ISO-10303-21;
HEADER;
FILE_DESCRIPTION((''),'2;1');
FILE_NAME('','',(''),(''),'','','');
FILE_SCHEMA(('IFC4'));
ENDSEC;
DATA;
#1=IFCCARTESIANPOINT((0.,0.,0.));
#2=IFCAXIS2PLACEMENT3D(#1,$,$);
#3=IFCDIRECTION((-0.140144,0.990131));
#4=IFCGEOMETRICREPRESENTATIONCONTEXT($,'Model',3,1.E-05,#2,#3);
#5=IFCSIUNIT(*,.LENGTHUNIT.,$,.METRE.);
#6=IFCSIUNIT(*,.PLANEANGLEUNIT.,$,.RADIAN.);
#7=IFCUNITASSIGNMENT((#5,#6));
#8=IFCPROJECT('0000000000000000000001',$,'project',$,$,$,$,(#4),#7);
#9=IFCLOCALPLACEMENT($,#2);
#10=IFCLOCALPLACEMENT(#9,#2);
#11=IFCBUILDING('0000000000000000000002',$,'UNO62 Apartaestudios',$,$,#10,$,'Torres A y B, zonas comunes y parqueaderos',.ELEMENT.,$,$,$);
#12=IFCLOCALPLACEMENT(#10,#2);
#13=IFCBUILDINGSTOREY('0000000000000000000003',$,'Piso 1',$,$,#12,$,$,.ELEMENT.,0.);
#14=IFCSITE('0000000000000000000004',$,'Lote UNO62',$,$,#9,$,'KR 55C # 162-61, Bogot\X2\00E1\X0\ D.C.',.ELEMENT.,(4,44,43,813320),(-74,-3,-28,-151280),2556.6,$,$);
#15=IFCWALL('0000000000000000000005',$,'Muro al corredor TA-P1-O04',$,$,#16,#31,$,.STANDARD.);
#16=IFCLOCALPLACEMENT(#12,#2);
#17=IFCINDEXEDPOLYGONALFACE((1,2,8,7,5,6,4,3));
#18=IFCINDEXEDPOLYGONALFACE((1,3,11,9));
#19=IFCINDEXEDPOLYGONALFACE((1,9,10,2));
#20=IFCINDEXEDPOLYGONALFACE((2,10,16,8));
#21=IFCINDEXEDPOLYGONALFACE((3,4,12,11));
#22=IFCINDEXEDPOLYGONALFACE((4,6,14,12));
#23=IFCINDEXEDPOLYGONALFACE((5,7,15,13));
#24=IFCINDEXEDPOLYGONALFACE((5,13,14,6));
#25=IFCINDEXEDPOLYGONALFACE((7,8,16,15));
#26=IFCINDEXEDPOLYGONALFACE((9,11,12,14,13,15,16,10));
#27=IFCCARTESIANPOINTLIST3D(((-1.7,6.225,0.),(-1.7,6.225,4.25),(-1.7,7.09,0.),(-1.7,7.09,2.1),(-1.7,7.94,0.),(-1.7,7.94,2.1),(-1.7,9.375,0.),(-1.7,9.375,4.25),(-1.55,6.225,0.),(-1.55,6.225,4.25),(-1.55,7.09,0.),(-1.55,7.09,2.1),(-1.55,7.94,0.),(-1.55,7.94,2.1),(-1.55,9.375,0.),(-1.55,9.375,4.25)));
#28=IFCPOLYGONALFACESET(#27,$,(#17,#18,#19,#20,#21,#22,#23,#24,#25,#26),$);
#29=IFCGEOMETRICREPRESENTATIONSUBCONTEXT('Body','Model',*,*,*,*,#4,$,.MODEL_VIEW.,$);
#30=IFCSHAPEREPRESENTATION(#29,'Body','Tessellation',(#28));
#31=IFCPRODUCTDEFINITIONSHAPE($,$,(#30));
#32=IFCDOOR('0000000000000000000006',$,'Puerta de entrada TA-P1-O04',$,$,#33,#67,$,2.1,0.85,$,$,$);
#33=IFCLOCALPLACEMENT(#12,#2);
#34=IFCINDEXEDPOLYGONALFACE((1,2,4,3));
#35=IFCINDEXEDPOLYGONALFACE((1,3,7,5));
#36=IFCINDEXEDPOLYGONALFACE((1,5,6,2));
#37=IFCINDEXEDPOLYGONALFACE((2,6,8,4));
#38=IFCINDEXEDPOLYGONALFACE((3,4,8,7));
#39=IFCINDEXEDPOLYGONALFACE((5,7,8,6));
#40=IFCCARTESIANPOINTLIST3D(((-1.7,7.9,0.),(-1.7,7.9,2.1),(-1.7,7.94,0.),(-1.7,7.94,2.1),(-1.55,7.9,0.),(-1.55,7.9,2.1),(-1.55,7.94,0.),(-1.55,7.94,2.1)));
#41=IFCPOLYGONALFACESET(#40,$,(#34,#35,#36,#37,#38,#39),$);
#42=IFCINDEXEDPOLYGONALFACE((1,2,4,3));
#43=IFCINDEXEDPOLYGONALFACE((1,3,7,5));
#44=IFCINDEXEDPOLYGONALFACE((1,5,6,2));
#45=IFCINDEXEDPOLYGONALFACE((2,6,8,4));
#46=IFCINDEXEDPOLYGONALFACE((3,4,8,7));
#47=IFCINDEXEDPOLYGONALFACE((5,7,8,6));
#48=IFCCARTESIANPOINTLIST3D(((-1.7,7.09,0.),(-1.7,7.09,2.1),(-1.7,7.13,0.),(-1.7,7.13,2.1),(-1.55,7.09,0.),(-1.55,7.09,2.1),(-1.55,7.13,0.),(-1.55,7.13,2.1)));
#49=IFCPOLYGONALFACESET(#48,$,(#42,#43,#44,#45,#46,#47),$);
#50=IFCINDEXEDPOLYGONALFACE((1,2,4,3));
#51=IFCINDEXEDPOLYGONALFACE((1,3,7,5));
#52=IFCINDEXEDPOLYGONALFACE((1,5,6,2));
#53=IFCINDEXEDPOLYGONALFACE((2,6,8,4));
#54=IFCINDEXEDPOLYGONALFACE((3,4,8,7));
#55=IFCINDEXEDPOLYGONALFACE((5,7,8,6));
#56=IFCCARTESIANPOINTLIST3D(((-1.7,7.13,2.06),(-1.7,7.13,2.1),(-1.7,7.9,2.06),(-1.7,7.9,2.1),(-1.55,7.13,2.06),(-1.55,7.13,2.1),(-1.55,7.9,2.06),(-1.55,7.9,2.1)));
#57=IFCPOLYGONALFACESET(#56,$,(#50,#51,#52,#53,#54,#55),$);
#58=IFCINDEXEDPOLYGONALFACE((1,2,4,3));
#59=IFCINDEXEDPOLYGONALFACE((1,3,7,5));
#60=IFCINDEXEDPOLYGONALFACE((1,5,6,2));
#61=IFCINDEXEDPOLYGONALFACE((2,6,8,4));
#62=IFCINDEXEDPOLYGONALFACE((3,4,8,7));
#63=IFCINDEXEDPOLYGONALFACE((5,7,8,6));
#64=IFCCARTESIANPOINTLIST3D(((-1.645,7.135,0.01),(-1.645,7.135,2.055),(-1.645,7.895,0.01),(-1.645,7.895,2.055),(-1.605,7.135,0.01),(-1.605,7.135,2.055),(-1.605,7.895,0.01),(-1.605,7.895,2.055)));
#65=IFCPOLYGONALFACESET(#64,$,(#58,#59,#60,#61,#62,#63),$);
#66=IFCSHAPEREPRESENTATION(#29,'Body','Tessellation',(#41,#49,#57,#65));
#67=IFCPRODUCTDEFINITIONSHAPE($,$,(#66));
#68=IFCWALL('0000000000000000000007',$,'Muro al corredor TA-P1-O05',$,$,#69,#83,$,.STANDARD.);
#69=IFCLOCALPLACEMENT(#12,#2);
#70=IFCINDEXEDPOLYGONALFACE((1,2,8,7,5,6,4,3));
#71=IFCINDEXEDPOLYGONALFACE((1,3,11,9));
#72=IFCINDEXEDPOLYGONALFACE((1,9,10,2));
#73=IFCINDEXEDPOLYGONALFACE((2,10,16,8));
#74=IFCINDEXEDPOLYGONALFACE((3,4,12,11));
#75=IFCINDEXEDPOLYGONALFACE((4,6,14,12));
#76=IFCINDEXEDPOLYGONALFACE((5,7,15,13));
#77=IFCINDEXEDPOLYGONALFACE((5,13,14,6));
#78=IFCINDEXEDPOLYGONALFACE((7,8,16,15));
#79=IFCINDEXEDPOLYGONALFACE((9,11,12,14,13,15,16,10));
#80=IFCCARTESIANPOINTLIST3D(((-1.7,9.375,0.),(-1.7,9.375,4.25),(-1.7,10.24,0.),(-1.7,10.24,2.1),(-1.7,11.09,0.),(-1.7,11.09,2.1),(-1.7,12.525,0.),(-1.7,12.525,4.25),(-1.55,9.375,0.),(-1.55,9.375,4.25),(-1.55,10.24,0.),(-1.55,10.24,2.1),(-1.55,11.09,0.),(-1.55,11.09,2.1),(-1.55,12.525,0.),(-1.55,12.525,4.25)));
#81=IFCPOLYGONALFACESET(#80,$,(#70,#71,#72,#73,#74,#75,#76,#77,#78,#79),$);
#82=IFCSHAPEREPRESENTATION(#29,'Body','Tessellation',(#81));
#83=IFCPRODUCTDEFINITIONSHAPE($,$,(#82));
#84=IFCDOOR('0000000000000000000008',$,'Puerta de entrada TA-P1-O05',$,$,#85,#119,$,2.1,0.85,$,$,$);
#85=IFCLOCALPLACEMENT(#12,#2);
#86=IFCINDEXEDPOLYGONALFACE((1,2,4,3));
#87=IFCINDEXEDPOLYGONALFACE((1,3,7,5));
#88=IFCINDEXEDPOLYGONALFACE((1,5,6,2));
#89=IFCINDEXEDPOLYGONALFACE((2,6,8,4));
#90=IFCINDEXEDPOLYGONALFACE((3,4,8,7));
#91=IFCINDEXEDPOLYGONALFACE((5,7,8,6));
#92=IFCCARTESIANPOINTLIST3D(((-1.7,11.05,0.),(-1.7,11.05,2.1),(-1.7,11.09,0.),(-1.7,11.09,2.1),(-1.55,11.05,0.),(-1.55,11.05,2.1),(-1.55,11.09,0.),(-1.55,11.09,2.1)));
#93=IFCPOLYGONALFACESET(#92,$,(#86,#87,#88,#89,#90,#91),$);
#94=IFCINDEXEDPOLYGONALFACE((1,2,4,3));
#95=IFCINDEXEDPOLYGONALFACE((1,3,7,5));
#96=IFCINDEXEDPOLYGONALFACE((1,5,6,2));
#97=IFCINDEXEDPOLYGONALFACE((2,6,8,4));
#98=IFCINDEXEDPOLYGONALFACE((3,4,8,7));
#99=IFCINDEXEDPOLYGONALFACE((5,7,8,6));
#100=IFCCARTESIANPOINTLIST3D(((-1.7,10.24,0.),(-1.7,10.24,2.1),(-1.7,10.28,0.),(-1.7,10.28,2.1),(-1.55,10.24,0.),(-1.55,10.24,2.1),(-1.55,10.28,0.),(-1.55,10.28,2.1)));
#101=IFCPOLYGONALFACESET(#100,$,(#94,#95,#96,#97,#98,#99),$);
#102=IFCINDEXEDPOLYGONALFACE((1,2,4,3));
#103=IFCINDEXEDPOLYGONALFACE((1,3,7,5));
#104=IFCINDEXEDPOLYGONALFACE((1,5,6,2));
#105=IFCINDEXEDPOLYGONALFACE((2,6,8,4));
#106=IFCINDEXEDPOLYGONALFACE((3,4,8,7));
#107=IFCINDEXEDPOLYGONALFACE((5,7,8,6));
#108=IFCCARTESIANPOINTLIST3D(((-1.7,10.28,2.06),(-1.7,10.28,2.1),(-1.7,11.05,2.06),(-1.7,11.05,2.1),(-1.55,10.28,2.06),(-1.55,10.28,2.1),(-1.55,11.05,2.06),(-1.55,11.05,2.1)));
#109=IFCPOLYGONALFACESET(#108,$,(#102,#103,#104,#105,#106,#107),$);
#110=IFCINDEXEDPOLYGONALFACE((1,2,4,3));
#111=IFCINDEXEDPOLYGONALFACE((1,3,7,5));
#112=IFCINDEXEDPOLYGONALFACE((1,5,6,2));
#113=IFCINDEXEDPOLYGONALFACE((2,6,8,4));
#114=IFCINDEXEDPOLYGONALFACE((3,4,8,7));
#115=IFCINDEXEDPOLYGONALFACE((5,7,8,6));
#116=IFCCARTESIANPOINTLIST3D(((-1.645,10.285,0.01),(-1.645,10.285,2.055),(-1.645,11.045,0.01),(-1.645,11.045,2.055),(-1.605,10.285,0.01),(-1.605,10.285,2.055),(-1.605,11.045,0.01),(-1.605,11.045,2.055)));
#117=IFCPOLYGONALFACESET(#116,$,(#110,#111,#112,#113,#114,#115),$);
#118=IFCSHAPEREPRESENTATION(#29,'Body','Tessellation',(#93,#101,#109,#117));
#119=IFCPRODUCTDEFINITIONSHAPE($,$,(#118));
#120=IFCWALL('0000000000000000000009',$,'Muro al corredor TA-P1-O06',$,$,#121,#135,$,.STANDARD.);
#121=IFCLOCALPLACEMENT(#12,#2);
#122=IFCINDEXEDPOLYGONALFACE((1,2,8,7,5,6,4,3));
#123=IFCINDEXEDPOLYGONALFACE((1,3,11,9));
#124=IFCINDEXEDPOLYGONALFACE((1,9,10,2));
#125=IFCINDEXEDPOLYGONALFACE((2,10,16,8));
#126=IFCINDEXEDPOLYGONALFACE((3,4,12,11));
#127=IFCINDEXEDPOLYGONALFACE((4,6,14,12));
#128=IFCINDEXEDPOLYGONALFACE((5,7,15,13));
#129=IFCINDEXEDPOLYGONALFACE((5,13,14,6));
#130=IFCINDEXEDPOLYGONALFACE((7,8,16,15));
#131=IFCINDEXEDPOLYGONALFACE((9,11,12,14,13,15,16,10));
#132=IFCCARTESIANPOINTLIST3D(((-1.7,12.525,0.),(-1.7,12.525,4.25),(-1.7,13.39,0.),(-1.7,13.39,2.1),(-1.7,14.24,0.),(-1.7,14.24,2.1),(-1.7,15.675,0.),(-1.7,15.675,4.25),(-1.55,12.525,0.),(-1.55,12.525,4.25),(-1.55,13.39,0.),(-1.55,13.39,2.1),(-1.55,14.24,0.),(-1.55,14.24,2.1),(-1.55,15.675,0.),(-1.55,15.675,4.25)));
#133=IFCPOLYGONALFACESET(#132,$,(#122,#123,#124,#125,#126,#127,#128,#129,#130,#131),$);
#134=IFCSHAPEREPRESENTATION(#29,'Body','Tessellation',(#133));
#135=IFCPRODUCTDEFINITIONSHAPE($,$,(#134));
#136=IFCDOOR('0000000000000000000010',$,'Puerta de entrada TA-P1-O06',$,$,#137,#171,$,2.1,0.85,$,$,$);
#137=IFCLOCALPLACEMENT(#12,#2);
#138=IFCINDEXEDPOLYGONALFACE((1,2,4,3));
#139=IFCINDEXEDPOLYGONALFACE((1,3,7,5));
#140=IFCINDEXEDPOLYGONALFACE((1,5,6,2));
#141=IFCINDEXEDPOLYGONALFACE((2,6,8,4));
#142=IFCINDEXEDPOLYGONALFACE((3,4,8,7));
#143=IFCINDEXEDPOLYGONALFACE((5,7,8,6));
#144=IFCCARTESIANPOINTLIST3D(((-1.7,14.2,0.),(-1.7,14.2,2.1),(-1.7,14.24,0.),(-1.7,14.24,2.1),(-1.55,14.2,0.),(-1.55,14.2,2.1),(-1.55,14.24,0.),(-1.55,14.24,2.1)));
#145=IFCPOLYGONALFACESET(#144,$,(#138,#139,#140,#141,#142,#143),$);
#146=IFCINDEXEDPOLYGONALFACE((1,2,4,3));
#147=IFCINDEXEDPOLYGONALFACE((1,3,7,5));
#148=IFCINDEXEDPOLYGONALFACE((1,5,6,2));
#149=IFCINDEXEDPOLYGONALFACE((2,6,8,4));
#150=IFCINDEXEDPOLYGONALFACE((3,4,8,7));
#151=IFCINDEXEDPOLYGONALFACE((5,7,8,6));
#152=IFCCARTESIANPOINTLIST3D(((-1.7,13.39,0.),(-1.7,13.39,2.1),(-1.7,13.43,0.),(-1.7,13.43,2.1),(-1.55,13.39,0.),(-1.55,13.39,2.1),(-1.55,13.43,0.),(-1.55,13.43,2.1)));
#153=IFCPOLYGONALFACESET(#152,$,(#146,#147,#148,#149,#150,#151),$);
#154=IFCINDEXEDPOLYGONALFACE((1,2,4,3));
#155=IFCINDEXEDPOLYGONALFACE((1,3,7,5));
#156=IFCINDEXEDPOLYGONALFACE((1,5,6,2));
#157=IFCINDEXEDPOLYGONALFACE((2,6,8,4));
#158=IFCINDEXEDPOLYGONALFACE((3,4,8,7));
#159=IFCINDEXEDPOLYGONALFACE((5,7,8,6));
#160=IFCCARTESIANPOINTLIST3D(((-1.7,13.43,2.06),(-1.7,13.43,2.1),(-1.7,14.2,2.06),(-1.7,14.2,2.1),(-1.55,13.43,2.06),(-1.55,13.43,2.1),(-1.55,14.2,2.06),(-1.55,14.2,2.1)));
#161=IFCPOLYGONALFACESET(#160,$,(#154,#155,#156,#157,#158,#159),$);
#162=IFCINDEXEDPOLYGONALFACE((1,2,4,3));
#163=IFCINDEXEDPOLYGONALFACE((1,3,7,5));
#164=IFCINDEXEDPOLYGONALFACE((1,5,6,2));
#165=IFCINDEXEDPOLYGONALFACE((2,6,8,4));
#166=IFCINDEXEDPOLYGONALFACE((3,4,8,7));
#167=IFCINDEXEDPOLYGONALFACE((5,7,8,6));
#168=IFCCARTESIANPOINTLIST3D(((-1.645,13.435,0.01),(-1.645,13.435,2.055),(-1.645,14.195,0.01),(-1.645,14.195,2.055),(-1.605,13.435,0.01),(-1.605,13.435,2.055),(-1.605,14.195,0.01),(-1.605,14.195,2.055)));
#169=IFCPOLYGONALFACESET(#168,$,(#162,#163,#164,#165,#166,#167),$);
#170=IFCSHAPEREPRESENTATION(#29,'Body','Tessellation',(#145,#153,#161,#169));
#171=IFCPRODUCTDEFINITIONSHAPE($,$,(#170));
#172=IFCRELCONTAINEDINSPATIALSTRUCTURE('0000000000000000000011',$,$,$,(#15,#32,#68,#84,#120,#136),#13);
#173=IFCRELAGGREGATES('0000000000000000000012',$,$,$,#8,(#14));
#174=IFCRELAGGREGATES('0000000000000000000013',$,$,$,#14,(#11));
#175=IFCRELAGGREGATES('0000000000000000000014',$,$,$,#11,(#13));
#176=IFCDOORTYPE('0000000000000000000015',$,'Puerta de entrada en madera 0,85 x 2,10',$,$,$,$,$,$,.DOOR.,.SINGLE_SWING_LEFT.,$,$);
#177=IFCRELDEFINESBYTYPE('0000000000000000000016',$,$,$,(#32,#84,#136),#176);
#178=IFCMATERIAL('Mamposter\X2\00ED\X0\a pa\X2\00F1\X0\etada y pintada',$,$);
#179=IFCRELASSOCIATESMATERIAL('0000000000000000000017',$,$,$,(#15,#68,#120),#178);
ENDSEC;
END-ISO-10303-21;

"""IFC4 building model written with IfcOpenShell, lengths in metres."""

from ifc_helpers import new_model, si_unit, direction, frame, frame_2d, origin, place, context, subcontext, project, spatial, rectangle, extrude, source, transform, mapped, material, type_object, type_shapes, element, fill, save


model = new_model("IFC4")

# Units and contexts
model_context = context("Model", 3, precision=1e-05, world=origin(), true_north=direction((-0.140144, 0.990131)))
body_context = subcontext(model_context, "Body", "Model", "MODEL_VIEW")
ifc_project = project(units=[si_unit("LENGTHUNIT", "METRE"), si_unit("PLANEANGLEUNIT", "RADIAN")], contexts=[model_context])

# Site, building, storey
site_placement = place(None, origin())
site = spatial("IfcSite", under=ifc_project, at=site_placement, Name="Lote UNO62", LongName="KR 55C # 162-61, Bogotá D.C.", CompositionType="ELEMENT", RefLatitude=(4, 44, 43, 813320), RefLongitude=(-74, -3, -28, -151280), RefElevation=2556.6)
building_placement = place(site_placement, origin())
building = spatial("IfcBuilding", under=site, at=building_placement, Name="UNO62 Apartaestudios", LongName="Torres A y B, zonas comunes y parqueaderos", CompositionType="ELEMENT")
storey_placement = place(building_placement, origin())
storey = spatial("IfcBuildingStorey", under=building, at=storey_placement, Name="Piso 1", CompositionType="ELEMENT", Elevation=0.0)

# Walls, openings, doors
ifc_material = material(Name="Mampostería pañetada y pintada")
wall_1_placement = place(storey_placement, origin())
wall_1 = element("IfcWall", 1, at=wall_1_placement, inside=storey, material=ifc_material, Name="Muro al corredor TA-P1-O04", PredefinedType="STANDARD", context=body_context, shape_type="SweptSolid", body=[
    extrude(rectangle(XDim=0.15, YDim=3.15, at=frame_2d((-1.625, 7.8))), origin(), (0.0, 0.0, 1.0), 4.25),
])
opening_1_placement = place(wall_1_placement, origin())
opening_1 = element("IfcOpeningElement", 2, at=opening_1_placement, cuts=wall_1, PredefinedType="OPENING", context=body_context, shape_type="SweptSolid", body=[
    extrude(rectangle(XDim=0.25, YDim=0.85, at=frame_2d((-1.625, 7.515))), origin(), (0.0, 0.0, 1.0), 2.1),
])
door_type = type_object("IfcDoorType", Name="Puerta de entrada en madera 0,85 x 2,10", OperationType="SINGLE_SWING_LEFT", PredefinedType="DOOR")
shared_shape = source(origin(), body_context, "Body", "SweptSolid", [
    extrude(rectangle(XDim=0.15, YDim=0.04, at=frame_2d((-0.075, 1.38))), origin(), (0.0, 0.0, 1.0), 2.1),
    extrude(rectangle(XDim=0.15, YDim=0.04, at=frame_2d((-0.075, 2.19))), origin(), (0.0, 0.0, 1.0), 2.1),
    extrude(rectangle(XDim=0.15, YDim=0.77, at=frame_2d((-0.075, 1.785))), frame((0.0, 0.0, 2.06)), (0.0, 0.0, 1.0), 0.04),
    extrude(rectangle(XDim=0.04, YDim=0.76, at=frame_2d((-0.075, 1.785))), frame((0.0, 0.0, 0.01)), (0.0, 0.0, 1.0), 2.045),
])
type_shapes(door_type, [shared_shape])
placement_1 = place(storey_placement, frame((-1.7, 9.3, 0.0), z_axis=(0.0, 0.0, 1.0), x_axis=(-1.0, 0.0, 0.0)))
door_1_placement = place(placement_1, origin())
door_1 = element("IfcDoor", 3, at=door_1_placement, inside=storey, type_object=door_type, Name="Puerta de entrada TA-P1-O04", OverallHeight=2.1, OverallWidth=0.85, context=body_context, shape_type="MappedRepresentation", body=[
    mapped(shared_shape, transform((0.0, 0.0, 0.0))),
])
fill(opening_1, door_1)
wall_2_placement = place(storey_placement, origin())
wall_2 = element("IfcWall", 4, at=wall_2_placement, inside=storey, material=ifc_material, Name="Muro al corredor TA-P1-O05", PredefinedType="STANDARD", context=body_context, shape_type="SweptSolid", body=[
    extrude(rectangle(XDim=0.15, YDim=3.15, at=frame_2d((-1.625, 10.95))), origin(), (0.0, 0.0, 1.0), 4.25),
])
opening_2_placement = place(wall_2_placement, origin())
opening_2 = element("IfcOpeningElement", 5, at=opening_2_placement, cuts=wall_2, PredefinedType="OPENING", context=body_context, shape_type="SweptSolid", body=[
    extrude(rectangle(XDim=0.25, YDim=0.85, at=frame_2d((-1.625, 10.665))), origin(), (0.0, 0.0, 1.0), 2.1),
])
placement_2 = place(storey_placement, frame((-1.7, 12.45, 0.0), z_axis=(0.0, 0.0, 1.0), x_axis=(-1.0, 0.0, 0.0)))
door_2_placement = place(placement_2, origin())
door_2 = element("IfcDoor", 6, at=door_2_placement, inside=storey, type_object=door_type, Name="Puerta de entrada TA-P1-O05", OverallHeight=2.1, OverallWidth=0.85, context=body_context, shape_type="MappedRepresentation", body=[
    mapped(shared_shape, transform((0.0, 0.0, 0.0))),
])
fill(opening_2, door_2)
wall_3_placement = place(storey_placement, origin())
wall_3 = element("IfcWall", 7, at=wall_3_placement, inside=storey, material=ifc_material, Name="Muro al corredor TA-P1-O06", PredefinedType="STANDARD", context=body_context, shape_type="SweptSolid", body=[
    extrude(rectangle(XDim=0.15, YDim=3.15, at=frame_2d((-1.625, 14.1))), origin(), (0.0, 0.0, 1.0), 4.25),
])
opening_3_placement = place(wall_3_placement, origin())
opening_3 = element("IfcOpeningElement", 8, at=opening_3_placement, cuts=wall_3, PredefinedType="OPENING", context=body_context, shape_type="SweptSolid", body=[
    extrude(rectangle(XDim=0.25, YDim=0.85, at=frame_2d((-1.625, 13.815))), origin(), (0.0, 0.0, 1.0), 2.1),
])
placement_3 = place(storey_placement, frame((-1.7, 15.6, 0.0), z_axis=(0.0, 0.0, 1.0), x_axis=(-1.0, 0.0, 0.0)))
door_3_placement = place(placement_3, origin())
door_3 = element("IfcDoor", 9, at=door_3_placement, inside=storey, type_object=door_type, Name="Puerta de entrada TA-P1-O06", OverallHeight=2.1, OverallWidth=0.85, context=body_context, shape_type="MappedRepresentation", body=[
    mapped(shared_shape, transform((0.0, 0.0, 0.0))),
])
fill(opening_3, door_3)

save(model, "model.ifc")
